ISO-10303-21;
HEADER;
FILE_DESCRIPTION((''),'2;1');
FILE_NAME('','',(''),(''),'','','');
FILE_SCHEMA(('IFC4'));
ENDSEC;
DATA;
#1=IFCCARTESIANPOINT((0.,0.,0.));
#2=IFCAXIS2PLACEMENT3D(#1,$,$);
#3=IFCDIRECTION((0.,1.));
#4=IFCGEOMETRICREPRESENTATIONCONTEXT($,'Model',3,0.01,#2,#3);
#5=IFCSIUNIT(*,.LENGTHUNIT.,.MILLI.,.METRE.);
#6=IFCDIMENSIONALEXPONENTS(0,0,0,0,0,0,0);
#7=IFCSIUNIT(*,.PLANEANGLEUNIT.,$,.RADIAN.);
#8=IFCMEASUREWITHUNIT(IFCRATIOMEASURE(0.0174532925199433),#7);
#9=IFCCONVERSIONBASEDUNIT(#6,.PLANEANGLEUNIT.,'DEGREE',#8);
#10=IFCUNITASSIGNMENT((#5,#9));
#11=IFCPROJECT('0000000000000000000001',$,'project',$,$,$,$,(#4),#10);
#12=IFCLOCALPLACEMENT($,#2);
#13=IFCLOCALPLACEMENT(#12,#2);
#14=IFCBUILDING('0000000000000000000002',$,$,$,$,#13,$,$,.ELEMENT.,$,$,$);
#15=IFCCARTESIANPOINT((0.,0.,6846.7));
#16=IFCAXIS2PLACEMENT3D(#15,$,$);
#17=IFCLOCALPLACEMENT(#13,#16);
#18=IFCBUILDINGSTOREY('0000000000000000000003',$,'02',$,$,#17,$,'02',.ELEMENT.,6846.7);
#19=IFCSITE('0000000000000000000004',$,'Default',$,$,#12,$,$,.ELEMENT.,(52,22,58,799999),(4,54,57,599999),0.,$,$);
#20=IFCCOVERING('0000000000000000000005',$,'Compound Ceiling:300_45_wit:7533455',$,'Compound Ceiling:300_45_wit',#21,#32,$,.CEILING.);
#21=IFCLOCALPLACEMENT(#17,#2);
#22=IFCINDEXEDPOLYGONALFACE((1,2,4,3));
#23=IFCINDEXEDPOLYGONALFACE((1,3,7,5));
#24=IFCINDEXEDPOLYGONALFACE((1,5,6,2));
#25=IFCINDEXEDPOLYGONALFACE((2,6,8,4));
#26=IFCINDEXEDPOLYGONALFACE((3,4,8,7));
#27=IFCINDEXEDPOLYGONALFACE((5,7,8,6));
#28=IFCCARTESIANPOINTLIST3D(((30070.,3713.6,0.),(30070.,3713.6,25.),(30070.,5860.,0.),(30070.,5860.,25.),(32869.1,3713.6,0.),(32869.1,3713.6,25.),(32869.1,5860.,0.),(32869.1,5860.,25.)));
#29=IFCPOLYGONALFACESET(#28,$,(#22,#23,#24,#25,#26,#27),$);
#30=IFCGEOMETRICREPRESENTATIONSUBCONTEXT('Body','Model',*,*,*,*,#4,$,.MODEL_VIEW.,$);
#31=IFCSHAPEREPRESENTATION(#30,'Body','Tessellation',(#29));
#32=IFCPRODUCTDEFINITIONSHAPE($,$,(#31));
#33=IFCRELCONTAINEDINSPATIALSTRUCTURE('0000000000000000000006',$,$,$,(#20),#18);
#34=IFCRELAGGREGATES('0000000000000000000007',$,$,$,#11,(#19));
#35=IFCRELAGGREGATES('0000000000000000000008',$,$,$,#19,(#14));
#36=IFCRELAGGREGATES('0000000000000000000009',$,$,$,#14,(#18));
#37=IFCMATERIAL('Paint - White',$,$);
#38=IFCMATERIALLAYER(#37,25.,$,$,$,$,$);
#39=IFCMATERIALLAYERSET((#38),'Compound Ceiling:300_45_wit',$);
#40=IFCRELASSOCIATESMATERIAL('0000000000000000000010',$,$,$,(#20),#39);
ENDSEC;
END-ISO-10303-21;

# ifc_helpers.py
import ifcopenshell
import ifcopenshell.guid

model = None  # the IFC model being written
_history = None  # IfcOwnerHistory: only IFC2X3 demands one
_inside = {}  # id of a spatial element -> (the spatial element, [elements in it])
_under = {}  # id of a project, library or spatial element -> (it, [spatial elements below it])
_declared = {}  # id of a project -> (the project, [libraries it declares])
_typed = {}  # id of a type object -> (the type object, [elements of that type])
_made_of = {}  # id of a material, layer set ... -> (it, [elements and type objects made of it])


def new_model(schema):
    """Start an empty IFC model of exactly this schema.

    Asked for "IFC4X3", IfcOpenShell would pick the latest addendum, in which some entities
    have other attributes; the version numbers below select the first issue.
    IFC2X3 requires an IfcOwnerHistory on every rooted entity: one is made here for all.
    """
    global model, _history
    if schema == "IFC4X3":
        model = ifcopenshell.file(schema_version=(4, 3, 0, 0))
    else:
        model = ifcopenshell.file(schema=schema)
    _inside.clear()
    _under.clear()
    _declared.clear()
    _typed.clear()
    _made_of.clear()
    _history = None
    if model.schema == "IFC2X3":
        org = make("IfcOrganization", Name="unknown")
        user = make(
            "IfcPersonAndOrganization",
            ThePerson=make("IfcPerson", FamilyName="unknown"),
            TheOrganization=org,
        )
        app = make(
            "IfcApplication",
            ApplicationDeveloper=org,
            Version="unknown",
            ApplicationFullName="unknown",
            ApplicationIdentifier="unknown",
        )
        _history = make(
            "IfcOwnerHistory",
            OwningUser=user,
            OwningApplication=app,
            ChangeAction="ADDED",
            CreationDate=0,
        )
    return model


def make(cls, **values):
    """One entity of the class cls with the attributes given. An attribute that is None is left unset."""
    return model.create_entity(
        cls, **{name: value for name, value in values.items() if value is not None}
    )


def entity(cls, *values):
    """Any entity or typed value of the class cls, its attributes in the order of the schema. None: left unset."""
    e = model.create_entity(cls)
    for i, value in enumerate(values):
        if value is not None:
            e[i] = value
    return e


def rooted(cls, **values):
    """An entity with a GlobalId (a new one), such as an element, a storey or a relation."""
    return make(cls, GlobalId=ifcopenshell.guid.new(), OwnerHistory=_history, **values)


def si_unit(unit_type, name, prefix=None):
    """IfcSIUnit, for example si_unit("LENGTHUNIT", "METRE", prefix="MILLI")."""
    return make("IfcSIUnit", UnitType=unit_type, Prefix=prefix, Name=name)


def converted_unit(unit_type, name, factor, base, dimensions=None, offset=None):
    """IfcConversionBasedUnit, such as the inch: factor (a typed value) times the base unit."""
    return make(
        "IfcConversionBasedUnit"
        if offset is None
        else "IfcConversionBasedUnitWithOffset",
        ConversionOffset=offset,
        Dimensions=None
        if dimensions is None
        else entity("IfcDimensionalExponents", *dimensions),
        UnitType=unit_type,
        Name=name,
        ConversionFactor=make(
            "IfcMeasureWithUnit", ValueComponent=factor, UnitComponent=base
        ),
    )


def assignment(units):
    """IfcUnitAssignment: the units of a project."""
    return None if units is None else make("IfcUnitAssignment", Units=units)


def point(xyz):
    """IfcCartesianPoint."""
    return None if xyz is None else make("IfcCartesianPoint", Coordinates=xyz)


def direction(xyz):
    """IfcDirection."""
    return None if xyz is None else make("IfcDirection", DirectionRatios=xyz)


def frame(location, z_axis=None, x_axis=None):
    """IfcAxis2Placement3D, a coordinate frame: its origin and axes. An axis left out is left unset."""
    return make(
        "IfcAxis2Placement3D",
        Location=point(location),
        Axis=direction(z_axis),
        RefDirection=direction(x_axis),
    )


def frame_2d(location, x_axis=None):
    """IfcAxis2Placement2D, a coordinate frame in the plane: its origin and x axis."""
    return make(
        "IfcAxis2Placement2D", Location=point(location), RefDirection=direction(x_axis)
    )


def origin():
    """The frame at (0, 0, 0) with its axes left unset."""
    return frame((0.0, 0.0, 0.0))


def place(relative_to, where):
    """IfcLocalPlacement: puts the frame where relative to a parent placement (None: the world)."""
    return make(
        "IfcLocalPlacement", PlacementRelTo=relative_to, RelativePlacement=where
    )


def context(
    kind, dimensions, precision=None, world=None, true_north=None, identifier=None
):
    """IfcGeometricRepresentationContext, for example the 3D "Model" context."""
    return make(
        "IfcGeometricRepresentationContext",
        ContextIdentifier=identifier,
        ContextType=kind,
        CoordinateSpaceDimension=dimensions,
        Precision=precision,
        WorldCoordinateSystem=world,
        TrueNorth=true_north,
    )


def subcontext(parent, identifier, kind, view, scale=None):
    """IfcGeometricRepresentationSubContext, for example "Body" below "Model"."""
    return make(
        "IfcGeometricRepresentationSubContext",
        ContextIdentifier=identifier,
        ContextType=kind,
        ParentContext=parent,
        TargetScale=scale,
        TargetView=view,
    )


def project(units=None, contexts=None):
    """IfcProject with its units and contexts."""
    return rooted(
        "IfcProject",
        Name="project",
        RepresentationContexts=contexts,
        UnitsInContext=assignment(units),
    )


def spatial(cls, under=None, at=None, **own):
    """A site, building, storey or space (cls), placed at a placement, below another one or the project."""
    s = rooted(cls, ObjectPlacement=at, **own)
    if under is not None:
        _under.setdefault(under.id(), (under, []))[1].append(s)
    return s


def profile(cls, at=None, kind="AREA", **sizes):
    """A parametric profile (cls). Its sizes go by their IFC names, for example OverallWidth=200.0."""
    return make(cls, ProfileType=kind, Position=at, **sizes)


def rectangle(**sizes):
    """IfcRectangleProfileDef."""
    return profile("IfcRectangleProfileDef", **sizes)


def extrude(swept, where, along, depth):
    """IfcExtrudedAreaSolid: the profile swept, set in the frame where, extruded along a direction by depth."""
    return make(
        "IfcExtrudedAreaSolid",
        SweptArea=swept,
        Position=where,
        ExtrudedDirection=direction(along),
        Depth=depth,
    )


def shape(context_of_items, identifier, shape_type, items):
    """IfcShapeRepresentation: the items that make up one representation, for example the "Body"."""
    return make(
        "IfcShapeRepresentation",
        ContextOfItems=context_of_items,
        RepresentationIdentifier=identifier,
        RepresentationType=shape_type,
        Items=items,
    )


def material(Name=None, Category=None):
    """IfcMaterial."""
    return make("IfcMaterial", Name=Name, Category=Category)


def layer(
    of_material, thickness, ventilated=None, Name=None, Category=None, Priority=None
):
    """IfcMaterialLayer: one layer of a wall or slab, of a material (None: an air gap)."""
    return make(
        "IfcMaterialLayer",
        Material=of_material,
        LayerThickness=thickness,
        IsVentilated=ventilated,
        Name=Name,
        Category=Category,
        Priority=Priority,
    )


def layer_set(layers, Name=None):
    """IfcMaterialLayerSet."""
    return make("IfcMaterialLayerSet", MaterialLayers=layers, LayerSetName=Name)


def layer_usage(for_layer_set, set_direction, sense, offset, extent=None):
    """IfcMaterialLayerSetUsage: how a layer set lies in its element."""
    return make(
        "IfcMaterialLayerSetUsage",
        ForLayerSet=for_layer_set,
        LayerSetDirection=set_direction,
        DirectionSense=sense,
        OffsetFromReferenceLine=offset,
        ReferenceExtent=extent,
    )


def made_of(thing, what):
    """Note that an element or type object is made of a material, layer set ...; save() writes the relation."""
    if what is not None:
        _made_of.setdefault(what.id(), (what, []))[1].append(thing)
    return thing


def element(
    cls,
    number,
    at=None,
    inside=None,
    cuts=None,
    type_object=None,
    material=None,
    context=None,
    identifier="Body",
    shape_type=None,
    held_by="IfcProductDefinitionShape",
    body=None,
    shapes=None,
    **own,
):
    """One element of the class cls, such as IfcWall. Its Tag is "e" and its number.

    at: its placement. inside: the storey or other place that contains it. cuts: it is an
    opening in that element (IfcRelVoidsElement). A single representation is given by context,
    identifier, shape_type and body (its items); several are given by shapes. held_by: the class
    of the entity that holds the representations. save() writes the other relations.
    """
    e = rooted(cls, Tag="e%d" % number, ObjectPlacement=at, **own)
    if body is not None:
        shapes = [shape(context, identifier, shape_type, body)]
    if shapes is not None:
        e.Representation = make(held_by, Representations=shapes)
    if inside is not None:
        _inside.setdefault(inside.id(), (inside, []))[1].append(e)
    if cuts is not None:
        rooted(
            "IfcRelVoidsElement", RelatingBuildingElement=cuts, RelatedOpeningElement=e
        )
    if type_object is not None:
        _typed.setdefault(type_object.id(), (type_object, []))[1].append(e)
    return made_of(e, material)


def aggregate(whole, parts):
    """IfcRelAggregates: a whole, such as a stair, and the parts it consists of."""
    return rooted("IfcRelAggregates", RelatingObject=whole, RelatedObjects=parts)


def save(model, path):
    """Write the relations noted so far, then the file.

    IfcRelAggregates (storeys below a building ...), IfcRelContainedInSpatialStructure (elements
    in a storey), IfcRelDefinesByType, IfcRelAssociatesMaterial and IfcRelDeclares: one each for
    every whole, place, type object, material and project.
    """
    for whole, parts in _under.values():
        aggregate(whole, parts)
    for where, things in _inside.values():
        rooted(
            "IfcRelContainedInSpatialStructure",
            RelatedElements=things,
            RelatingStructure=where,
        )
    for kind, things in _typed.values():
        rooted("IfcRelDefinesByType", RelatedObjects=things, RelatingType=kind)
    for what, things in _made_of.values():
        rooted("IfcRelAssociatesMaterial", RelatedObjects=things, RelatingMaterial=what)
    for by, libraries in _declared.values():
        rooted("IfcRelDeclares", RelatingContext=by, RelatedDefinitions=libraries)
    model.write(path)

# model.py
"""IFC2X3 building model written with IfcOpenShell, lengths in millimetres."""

from ifc_helpers import new_model, entity, si_unit, converted_unit, direction, frame, frame_2d, origin, place, context, subcontext, project, spatial, rectangle, extrude, material, layer, layer_set, layer_usage, element, save


model = new_model("IFC2X3")

# Units and contexts
model_context = context("Model", 3, precision=0.01, world=origin(), true_north=direction((0.0, 1.0)))
body_context = subcontext(model_context, "Body", "Model", "MODEL_VIEW")
ifc_project = project(units=[si_unit("LENGTHUNIT", "METRE", prefix="MILLI"), converted_unit("PLANEANGLEUNIT", "DEGREE", entity("IfcRatioMeasure", 0.0174532925199433), si_unit("PLANEANGLEUNIT", "RADIAN"), dimensions=[0, 0, 0, 0, 0, 0, 0])], contexts=[model_context])

# Site, building, storey
site_placement = place(None, origin())
site = spatial("IfcSite", under=ifc_project, at=site_placement, Name="Default", CompositionType="ELEMENT", RefLatitude=(52, 22, 58, 799999), RefLongitude=(4, 54, 57, 599999), RefElevation=0.0)
building_placement = place(site_placement, origin())
building = spatial("IfcBuilding", under=site, at=building_placement, CompositionType="ELEMENT")
storey_placement = place(building_placement, frame((0.0, 0.0, 6846.7)))
storey = spatial("IfcBuildingStorey", under=building, at=storey_placement, Name="02", LongName="02", CompositionType="ELEMENT", Elevation=6846.7)

# Covering
ifc_material_1 = material(Name="Paint - White")
ifc_layer_1 = layer(ifc_material_1, 25.0)
ifc_layer_set_1 = layer_set([ifc_layer_1], Name="Compound Ceiling:300_45_wit")
ifc_layer_usage_1 = layer_usage(ifc_layer_set_1, "AXIS3", "NEGATIVE", 0.0)
covering_1_placement = place(storey_placement, origin())
element("IfcCovering", 1, at=covering_1_placement, inside=storey, material=ifc_layer_usage_1, Name="Compound Ceiling:300_45_wit:7533455", ObjectType="Compound Ceiling:300_45_wit", PredefinedType="CEILING", context=body_context, shape_type="SweptSolid", body=[
    extrude(rectangle(XDim=2799.1, YDim=2146.4, at=frame_2d((0.0, 0.0), x_axis=(1.0, 0.0))), frame((31469.5, 4786.8, 0.0)), (0.0, 0.0, 1.0), 25.0),
])

save(model, "model.ifc")
